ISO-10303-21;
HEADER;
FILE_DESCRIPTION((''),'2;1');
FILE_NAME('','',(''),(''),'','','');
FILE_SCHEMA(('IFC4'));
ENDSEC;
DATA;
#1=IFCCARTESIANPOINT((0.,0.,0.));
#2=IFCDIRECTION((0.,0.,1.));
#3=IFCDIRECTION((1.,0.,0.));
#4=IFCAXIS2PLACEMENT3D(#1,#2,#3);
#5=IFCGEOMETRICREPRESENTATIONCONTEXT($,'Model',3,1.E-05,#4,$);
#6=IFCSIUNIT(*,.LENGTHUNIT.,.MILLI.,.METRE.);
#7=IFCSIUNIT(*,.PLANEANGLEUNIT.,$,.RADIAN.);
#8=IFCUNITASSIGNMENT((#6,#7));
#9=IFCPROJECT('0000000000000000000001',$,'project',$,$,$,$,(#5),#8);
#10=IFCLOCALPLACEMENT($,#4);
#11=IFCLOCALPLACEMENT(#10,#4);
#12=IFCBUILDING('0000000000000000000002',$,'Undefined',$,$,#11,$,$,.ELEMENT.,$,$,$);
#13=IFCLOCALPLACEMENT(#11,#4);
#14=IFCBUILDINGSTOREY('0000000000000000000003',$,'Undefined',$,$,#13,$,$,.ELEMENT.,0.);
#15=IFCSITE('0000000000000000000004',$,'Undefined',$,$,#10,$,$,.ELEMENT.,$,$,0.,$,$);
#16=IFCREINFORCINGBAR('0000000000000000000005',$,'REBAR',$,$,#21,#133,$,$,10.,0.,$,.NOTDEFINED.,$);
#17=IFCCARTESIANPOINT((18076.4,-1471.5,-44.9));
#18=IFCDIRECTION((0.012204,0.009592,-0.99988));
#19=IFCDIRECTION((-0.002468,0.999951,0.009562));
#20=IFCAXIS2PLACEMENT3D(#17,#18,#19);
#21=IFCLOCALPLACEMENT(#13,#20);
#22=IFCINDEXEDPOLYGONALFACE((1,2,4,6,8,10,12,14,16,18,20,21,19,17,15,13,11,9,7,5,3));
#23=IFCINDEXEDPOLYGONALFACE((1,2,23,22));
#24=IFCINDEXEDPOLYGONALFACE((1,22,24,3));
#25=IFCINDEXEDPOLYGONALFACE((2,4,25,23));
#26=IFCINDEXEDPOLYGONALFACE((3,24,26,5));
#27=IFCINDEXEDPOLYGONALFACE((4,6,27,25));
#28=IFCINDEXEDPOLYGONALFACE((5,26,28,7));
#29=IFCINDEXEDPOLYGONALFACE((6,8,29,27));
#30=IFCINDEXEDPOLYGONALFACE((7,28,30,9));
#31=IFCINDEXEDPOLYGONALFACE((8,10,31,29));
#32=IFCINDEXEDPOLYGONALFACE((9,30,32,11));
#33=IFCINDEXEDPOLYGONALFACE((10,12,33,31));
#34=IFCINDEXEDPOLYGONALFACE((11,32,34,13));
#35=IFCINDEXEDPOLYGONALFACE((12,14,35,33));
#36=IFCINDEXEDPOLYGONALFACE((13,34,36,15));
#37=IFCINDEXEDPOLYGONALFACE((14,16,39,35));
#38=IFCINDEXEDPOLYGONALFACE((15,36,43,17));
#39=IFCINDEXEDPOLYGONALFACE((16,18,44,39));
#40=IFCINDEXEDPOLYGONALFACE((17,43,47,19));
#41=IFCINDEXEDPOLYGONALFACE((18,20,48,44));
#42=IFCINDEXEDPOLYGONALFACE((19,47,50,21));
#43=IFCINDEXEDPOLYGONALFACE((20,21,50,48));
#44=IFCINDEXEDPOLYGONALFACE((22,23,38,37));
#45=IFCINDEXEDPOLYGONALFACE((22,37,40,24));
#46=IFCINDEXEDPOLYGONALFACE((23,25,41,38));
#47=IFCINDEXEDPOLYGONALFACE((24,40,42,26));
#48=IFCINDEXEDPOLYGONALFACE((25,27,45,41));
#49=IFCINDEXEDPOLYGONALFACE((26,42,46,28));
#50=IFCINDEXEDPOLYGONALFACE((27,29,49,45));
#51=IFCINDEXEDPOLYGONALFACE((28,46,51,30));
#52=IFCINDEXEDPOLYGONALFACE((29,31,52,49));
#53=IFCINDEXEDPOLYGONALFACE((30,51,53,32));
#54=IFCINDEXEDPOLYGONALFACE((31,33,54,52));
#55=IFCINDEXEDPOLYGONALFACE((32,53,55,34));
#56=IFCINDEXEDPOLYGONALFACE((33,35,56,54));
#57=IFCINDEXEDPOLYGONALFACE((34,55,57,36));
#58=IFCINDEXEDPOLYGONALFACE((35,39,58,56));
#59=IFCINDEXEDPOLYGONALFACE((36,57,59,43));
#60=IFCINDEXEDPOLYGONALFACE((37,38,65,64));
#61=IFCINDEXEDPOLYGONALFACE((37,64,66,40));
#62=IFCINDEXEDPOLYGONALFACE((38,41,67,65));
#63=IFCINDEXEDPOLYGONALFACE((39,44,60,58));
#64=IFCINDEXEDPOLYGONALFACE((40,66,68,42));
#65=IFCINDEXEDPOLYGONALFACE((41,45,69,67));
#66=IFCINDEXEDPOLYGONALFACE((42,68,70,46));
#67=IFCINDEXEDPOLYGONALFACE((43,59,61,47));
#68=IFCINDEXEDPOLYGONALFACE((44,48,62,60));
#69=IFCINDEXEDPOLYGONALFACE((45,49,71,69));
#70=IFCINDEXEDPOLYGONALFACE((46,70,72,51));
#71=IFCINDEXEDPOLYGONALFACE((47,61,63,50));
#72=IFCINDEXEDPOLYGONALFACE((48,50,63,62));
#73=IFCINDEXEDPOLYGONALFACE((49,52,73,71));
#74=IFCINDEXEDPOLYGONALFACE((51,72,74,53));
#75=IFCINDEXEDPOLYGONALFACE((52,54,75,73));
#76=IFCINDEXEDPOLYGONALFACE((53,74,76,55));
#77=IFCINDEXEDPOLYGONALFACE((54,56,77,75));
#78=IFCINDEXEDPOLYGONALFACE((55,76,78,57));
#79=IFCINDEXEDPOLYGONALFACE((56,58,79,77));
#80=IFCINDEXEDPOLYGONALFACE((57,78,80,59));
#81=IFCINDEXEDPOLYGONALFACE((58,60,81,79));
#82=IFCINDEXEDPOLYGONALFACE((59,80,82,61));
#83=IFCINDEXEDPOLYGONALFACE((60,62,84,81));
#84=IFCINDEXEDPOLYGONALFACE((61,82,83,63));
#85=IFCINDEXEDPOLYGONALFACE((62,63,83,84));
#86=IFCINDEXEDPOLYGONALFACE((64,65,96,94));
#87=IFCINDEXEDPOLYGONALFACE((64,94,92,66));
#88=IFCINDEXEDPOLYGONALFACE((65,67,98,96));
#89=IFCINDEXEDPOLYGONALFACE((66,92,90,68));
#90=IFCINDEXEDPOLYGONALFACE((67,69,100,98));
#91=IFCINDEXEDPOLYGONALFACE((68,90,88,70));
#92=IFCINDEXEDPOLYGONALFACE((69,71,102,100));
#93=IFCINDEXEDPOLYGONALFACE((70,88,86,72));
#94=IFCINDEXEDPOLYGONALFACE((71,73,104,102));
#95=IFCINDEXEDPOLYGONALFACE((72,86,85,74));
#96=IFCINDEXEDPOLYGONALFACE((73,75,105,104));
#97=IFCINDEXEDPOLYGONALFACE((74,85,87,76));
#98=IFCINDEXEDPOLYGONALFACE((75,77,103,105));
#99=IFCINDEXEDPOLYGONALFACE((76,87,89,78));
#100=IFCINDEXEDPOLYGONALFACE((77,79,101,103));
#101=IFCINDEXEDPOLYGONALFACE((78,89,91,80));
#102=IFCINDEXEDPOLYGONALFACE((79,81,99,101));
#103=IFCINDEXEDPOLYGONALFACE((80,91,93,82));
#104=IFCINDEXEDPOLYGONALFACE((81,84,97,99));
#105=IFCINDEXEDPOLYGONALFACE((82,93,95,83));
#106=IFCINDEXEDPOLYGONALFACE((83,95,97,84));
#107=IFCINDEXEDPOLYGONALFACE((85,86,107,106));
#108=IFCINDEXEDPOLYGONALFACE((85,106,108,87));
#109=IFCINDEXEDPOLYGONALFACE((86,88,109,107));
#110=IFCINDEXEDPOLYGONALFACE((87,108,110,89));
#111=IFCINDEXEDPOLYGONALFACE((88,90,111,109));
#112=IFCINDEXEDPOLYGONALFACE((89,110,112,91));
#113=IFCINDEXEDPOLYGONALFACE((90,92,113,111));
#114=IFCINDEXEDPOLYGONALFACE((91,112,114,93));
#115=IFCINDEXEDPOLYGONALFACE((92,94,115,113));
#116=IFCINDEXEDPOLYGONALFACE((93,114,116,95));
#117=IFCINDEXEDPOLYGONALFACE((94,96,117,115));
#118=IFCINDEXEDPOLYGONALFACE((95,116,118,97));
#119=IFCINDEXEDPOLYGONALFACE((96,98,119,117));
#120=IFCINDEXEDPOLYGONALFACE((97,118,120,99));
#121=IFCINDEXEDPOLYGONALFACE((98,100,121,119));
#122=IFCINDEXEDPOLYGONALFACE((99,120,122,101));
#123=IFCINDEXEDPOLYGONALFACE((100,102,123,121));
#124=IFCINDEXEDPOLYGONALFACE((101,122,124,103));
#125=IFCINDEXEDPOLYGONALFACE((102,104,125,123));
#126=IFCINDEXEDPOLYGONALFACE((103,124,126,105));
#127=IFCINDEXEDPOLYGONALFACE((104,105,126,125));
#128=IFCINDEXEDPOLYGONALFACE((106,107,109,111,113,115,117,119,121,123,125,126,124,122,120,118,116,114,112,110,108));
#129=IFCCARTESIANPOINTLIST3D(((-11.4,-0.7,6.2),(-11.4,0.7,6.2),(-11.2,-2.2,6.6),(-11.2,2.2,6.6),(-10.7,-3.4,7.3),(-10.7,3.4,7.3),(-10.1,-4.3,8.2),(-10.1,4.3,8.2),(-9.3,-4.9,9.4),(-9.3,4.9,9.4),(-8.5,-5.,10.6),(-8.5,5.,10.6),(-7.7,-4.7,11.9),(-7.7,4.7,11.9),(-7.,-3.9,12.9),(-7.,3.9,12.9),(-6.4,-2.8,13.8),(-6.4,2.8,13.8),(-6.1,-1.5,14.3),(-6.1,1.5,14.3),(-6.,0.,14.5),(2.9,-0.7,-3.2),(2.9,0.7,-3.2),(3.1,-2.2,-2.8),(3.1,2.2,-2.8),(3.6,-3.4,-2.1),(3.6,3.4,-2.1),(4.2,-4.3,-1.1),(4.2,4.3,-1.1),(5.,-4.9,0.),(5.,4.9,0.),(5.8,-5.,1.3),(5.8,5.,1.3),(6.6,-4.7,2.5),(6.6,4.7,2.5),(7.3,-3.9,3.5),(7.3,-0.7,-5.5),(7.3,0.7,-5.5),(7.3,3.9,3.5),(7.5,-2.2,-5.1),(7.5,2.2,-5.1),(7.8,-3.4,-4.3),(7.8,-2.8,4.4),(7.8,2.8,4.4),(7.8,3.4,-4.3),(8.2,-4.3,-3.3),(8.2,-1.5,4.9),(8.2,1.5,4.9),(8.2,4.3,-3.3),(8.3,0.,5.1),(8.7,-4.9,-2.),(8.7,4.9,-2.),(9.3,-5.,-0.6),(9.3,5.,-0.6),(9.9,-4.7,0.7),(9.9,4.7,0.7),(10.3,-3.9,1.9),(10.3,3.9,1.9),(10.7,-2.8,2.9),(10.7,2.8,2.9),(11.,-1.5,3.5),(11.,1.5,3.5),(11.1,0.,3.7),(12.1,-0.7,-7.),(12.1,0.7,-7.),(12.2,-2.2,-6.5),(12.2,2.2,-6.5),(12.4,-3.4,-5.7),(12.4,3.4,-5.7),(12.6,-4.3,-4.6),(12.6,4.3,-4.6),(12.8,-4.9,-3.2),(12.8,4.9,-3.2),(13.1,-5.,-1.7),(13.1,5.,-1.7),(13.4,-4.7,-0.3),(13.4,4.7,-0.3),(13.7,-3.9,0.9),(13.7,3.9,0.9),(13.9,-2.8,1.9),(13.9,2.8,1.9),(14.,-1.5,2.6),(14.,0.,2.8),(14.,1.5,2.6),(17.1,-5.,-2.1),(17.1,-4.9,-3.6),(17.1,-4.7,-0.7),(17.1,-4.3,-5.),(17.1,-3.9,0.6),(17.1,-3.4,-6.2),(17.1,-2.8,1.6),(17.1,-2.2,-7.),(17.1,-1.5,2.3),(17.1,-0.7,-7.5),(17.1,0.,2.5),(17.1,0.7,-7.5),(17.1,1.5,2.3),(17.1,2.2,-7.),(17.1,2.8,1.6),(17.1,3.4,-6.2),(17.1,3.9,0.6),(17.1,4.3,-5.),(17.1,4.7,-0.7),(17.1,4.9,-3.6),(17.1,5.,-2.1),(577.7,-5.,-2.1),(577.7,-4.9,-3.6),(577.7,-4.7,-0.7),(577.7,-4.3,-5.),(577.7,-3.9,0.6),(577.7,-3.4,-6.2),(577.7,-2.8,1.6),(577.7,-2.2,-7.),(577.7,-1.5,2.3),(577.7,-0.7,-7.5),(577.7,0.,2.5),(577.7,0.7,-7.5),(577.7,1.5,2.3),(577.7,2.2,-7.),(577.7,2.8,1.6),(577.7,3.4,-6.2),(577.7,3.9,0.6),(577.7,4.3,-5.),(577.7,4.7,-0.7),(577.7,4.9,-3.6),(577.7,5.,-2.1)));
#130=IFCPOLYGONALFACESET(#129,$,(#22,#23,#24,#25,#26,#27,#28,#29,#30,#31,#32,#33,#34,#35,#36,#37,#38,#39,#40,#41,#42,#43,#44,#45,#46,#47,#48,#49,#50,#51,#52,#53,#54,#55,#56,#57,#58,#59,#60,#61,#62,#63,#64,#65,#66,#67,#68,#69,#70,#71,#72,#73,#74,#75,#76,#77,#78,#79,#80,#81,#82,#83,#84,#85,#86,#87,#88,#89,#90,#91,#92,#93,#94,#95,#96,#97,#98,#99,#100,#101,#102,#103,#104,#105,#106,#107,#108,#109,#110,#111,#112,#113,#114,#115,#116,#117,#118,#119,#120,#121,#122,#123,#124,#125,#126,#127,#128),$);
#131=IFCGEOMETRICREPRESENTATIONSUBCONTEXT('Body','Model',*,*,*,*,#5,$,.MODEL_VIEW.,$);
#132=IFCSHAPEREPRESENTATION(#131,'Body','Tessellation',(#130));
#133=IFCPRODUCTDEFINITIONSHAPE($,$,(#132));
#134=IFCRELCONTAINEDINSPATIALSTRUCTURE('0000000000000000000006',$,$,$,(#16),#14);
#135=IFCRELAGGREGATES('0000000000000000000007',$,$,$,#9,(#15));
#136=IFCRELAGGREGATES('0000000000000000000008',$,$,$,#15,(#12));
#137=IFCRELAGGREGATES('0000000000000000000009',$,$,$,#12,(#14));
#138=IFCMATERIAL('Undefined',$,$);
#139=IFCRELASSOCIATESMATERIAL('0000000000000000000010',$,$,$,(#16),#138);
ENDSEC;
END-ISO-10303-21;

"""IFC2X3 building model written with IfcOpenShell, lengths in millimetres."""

from ifc_helpers import new_model, entity, si_unit, frame, origin_with_axes, place, context, subcontext, project, spatial, source, transform, mapped, material, element, save


model = new_model("IFC2X3")

# Units and contexts
model_context = context("Model", 3, precision=1e-05, world=origin_with_axes())
body_context = subcontext(model_context, "Body", "Model", "MODEL_VIEW")
ifc_project = project(units=[si_unit("LENGTHUNIT", "METRE", prefix="MILLI"), si_unit("PLANEANGLEUNIT", "RADIAN")], contexts=[model_context])

# Site, building, storey
site_placement = place(None, origin_with_axes())
site = spatial("IfcSite", under=ifc_project, at=site_placement, Name="Undefined", CompositionType="ELEMENT", RefElevation=0.0)
building_placement = place(site_placement, origin_with_axes())
building = spatial("IfcBuilding", under=site, at=building_placement, Name="Undefined", CompositionType="ELEMENT")
storey_placement = place(building_placement, origin_with_axes())
storey = spatial("IfcBuildingStorey", under=building, at=storey_placement, Name="Undefined", CompositionType="ELEMENT", Elevation=0.0)

# Reinforcing bar
ifc_material_1 = material(Name="Undefined")
shared_shape_1 = source(origin_with_axes(), body_context, "Body", "AdvancedSweptSolid", [
    entity("IfcSweptDiskSolid", entity("IfcCompositeCurve", [entity("IfcCompositeCurveSegment", "CONTINUOUS", True, entity("IfcTrimmedCurve", entity("IfcLine", entity("IfcCartesianPoint", [0.0, 0.0, 0.0]), entity("IfcVector", entity("IfcDirection", [0.835483, 0.0, -0.549516]), 1.0)), [entity("IfcParameterValue", 0.0)], [entity("IfcParameterValue", 17.082101)], True, "PARAMETER")), entity("IfcCompositeCurveSegment", "CONTINUOUS", True, entity("IfcTrimmedCurve", entity("IfcCircle", entity("IfcAxis2Placement3D", entity("IfcCartesianPoint", [25.8, 0.0, 8.2]), entity("IfcDirection", [0.0, -1.0, 0.0]), entity("IfcDirection", [-0.549516, 0.0, -0.835483])), 21.0), [entity("IfcParameterValue", 0.0)], [entity("IfcParameterValue", 0.581785)], True, "PARAMETER")), entity("IfcCompositeCurveSegment", "DISCONTINUOUS", True, entity("IfcTrimmedCurve", entity("IfcLine", entity("IfcCartesianPoint", [25.8, 0.0, -12.8]), entity("IfcVector", entity("IfcDirection", [1.0, 0.0, 0.0]), 1.0)), [entity("IfcParameterValue", 0.0)], [entity("IfcParameterValue", 560.593055)], True, "PARAMETER"))], False), 5.0, None, 0.0, 578.3),
])
reinforcing_bar_1_placement = place(storey_placement, frame((18076.4, -1471.5, -44.9), z_axis=(0.012204, 0.009592, -0.99988), x_axis=(-0.002468, 0.999951, 0.009562)))
element("IfcReinforcingBar", 1, at=reinforcing_bar_1_placement, inside=storey, material=ifc_material_1, Name="REBAR", BarRole="NOTDEFINED", CrossSectionArea=0.0, NominalDiameter=10.0, context=body_context, shape_type="MappedRepresentation", body=[
    mapped(shared_shape_1, transform((-8.7, 0.0, 10.3))),
])

save(model, "model.ifc")
